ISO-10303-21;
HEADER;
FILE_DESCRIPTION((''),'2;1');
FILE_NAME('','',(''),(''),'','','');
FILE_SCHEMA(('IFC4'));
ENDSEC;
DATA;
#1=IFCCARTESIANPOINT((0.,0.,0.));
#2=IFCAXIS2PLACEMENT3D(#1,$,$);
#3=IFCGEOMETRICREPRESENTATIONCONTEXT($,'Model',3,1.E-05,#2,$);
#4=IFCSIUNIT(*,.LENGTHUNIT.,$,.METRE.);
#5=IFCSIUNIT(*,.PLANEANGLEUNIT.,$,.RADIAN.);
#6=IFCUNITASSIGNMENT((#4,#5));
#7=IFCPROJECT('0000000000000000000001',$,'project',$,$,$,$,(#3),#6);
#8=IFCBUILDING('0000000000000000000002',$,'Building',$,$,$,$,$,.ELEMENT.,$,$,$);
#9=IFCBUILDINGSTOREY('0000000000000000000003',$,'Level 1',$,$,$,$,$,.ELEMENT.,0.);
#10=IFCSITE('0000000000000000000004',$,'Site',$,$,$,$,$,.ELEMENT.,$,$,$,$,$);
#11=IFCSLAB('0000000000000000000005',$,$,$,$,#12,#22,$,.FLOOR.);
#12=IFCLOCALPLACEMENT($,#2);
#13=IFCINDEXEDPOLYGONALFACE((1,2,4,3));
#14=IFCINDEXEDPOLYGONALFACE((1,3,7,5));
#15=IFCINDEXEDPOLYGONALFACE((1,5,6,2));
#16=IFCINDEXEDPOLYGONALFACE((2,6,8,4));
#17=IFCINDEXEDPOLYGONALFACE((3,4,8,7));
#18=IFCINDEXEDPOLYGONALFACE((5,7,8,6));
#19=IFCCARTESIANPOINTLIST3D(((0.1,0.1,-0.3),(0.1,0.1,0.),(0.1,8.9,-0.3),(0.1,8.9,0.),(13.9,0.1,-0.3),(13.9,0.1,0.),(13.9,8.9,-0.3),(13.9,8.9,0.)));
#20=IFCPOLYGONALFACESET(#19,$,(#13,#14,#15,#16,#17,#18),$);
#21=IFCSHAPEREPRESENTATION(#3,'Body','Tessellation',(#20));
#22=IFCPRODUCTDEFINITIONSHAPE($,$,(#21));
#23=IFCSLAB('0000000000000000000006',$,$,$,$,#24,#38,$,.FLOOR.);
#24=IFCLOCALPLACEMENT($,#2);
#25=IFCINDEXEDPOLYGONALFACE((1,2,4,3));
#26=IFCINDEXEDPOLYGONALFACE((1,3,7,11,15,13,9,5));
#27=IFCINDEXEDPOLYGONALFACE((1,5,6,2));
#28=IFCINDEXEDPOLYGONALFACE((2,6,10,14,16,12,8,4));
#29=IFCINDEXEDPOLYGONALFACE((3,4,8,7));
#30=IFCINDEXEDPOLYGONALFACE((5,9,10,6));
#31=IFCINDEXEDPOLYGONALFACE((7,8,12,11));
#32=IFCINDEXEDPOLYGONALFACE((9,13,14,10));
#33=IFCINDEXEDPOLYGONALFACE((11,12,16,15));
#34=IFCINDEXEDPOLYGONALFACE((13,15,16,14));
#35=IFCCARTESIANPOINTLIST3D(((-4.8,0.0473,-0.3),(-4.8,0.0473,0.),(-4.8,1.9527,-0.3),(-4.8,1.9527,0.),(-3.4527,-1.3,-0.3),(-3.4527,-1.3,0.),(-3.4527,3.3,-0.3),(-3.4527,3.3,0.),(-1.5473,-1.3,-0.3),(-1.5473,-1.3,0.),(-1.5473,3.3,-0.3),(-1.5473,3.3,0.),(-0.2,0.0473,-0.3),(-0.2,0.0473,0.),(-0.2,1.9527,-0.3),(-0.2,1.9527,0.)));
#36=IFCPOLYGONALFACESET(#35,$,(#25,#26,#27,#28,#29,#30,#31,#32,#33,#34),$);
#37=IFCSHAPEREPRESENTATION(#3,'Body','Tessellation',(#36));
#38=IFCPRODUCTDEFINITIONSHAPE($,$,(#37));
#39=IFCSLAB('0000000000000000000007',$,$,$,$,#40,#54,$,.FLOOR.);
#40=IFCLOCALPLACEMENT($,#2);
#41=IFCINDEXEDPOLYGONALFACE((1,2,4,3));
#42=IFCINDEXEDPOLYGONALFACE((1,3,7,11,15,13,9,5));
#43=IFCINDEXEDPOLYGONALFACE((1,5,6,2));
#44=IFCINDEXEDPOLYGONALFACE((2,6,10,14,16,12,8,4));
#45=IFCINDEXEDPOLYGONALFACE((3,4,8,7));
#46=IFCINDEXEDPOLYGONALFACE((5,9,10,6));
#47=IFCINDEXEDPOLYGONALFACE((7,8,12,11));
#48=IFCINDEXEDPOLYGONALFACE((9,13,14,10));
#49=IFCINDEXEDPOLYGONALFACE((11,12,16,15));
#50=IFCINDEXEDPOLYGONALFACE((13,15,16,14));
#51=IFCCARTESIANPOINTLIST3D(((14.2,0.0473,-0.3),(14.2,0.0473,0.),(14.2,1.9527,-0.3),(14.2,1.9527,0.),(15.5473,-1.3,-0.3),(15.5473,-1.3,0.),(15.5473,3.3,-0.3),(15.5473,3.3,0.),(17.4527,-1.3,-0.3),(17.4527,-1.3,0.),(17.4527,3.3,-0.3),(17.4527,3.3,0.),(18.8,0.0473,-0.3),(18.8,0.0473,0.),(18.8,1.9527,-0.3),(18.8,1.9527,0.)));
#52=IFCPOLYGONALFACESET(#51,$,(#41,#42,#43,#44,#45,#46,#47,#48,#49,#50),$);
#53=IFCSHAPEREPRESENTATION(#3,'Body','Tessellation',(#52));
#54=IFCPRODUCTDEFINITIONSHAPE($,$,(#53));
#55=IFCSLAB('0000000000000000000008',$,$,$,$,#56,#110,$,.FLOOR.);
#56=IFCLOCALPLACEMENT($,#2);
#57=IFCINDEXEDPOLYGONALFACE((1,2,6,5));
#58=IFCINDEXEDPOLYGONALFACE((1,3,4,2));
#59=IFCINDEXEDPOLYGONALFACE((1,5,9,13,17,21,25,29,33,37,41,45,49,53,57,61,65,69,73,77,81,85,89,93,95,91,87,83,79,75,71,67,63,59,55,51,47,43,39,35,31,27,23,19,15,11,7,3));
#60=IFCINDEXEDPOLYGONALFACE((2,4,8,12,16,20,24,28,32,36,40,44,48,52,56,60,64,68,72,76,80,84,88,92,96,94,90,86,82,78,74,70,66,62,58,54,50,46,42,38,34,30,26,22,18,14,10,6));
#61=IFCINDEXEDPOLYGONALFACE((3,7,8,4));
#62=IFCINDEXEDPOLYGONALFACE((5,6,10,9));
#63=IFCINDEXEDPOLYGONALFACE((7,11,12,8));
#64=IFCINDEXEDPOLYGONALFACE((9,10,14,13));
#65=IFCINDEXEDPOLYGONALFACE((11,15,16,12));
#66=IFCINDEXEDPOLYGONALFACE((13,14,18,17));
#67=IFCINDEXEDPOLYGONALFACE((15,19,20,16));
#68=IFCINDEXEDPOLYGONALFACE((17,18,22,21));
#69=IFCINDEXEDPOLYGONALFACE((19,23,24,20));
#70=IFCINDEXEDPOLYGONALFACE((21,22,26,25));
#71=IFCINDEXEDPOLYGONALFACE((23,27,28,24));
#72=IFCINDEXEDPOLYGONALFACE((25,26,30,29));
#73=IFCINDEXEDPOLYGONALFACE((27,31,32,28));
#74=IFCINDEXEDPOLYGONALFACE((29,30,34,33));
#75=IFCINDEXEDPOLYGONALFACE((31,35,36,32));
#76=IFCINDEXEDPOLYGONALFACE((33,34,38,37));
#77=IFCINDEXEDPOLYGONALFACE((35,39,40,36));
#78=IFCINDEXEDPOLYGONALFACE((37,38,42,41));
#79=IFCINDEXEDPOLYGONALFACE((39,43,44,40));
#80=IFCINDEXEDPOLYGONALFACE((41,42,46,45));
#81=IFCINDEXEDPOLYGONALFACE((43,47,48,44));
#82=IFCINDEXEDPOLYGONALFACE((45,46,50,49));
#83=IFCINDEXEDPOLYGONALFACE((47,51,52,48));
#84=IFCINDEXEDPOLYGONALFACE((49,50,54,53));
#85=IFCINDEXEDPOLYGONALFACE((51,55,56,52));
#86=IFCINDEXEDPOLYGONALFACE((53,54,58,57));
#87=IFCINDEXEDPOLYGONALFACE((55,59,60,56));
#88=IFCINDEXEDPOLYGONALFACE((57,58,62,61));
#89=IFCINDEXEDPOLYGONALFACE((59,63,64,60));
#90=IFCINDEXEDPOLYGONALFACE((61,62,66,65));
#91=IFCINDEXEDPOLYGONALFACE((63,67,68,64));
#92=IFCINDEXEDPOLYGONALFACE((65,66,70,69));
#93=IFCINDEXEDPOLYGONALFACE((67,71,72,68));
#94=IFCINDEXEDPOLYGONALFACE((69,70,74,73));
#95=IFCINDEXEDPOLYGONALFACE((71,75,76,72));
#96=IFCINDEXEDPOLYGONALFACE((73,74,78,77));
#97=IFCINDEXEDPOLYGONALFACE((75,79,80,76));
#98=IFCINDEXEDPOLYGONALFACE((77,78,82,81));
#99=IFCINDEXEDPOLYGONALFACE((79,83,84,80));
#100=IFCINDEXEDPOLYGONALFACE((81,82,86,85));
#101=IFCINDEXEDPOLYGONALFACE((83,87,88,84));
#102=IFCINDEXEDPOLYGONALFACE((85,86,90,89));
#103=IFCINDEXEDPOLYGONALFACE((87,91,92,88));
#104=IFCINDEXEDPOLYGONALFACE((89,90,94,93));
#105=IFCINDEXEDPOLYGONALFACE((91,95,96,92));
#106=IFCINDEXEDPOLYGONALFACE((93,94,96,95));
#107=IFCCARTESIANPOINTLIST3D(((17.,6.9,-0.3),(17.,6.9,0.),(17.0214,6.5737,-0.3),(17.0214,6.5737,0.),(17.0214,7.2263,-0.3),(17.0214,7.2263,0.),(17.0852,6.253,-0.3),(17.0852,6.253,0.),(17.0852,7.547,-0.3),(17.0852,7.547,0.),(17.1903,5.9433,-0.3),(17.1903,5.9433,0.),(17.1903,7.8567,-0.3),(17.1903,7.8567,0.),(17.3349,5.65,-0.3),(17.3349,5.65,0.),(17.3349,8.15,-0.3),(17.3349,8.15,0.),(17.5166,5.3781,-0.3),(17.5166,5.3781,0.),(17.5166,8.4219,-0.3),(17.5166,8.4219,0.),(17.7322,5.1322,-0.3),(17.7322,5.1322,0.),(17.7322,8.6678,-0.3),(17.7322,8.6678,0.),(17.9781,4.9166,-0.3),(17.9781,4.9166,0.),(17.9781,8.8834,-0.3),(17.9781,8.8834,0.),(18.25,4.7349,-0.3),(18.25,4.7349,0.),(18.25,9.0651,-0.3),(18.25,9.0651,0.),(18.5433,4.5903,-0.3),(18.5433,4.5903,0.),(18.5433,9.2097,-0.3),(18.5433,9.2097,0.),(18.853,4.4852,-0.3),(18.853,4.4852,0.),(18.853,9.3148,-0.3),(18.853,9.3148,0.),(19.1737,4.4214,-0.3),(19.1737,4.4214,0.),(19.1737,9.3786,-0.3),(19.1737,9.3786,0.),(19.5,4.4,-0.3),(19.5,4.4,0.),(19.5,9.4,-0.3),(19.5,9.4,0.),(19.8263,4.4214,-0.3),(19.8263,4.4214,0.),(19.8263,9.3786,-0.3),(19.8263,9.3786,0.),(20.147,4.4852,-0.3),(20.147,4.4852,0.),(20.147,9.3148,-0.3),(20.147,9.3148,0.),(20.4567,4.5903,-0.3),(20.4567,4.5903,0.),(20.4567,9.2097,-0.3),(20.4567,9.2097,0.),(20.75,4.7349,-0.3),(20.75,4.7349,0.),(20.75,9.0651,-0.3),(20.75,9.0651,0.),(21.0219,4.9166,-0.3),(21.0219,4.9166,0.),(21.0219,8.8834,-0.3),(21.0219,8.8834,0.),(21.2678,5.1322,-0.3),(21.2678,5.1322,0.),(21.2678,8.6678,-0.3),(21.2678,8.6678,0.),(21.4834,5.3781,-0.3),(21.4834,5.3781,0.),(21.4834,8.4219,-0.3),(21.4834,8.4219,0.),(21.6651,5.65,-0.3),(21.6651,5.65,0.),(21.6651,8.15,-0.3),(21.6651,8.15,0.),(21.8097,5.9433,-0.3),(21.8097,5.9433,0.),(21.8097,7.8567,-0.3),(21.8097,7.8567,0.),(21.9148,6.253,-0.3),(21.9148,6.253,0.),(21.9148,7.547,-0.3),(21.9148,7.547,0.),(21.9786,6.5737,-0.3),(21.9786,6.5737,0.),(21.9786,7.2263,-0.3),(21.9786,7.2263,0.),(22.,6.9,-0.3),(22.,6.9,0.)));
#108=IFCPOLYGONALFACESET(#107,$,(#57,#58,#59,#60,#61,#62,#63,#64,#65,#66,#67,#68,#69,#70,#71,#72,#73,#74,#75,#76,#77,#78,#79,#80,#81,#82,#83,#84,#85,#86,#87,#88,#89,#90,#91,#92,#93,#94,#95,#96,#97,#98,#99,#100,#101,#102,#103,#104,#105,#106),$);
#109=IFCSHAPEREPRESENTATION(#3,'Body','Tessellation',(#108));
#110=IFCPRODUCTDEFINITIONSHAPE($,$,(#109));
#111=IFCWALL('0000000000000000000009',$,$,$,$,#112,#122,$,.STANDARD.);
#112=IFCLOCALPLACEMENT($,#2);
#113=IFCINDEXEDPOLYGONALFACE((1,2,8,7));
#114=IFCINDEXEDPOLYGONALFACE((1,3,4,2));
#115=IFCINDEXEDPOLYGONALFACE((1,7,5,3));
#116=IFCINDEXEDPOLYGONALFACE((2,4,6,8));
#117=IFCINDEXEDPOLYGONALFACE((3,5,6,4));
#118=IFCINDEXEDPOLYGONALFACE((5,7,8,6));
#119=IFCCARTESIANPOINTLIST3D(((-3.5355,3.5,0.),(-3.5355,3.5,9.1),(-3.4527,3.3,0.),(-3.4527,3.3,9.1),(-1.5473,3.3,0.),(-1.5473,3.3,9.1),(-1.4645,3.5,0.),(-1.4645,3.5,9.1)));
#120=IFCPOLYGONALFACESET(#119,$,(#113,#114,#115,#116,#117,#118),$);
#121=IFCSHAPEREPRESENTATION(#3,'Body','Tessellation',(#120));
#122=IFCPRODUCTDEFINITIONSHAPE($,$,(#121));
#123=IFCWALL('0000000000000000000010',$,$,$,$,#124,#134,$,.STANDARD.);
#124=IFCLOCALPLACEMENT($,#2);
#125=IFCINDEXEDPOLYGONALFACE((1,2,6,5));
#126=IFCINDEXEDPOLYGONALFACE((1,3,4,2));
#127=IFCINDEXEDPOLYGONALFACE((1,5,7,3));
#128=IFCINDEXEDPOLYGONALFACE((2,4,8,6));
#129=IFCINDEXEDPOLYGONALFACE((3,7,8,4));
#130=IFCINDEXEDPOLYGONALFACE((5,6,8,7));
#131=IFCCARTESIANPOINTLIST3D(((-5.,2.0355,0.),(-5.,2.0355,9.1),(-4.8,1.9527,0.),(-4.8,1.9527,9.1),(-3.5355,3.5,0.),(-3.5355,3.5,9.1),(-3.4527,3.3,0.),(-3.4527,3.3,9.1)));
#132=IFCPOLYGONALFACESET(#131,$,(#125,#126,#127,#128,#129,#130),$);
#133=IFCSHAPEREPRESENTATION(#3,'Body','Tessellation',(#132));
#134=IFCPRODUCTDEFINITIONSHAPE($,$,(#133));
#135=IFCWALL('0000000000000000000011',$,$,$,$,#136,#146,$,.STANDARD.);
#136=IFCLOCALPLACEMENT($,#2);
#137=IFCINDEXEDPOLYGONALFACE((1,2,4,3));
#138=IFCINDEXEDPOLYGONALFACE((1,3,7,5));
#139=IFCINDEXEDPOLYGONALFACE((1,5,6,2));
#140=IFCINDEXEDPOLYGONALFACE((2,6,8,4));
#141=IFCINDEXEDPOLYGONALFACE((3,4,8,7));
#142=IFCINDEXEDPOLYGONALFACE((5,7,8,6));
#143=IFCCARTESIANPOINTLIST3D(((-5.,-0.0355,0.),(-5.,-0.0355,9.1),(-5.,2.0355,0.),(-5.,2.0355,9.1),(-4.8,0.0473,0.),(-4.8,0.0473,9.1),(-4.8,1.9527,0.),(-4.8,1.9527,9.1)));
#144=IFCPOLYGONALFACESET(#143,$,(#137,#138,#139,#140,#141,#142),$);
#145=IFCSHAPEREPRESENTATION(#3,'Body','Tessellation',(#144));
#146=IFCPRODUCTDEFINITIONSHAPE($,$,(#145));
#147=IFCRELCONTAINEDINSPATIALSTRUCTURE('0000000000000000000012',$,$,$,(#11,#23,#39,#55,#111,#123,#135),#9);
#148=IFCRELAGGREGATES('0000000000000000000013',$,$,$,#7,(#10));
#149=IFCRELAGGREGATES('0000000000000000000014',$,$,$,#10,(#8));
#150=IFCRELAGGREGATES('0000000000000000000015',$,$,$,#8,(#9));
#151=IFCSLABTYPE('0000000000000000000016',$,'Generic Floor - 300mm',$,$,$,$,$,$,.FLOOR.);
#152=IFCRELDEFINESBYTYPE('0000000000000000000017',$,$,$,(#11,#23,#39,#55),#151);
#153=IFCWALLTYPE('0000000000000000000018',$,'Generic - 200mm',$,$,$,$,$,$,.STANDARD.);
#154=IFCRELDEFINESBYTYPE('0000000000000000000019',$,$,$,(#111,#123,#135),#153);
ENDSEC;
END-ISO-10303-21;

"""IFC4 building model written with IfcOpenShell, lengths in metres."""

from ifc_helpers import new_model, si_unit, frame, origin, place, context, project, spatial, polyline, outline, extrude, type_object, element, save


model = new_model("IFC4")

# Units and contexts
model_context = context("Model", 3, precision=1e-05, world=origin())
ifc_project = project(units=[si_unit("LENGTHUNIT", "METRE"), si_unit("PLANEANGLEUNIT", "RADIAN")], contexts=[model_context])

# Site, building, storey
site = spatial("IfcSite", under=ifc_project, Name="Site", CompositionType="ELEMENT")
building = spatial("IfcBuilding", under=site, Name="Building", CompositionType="ELEMENT")
storey = spatial("IfcBuildingStorey", under=building, Name="Level 1", CompositionType="ELEMENT", Elevation=0.0)

# Slabs
slab_type = type_object("IfcSlabType", Name="Generic Floor - 300mm", PredefinedType="FLOOR")
slab_1_placement = place(None, origin())
element("IfcSlab", 1, at=slab_1_placement, inside=storey, type_object=slab_type, PredefinedType="FLOOR", context=model_context, shape_type="SweptSolid", body=[
    extrude(outline(polyline([(0.1, 0.1), (13.9, 0.1), (13.9, 8.9), (0.1, 8.9), (0.1, 0.1)])), origin(), (0.0, 0.0, -1.0), 0.3),
])
slab_2_placement = place(None, origin())
element("IfcSlab", 2, at=slab_2_placement, inside=storey, type_object=slab_type, PredefinedType="FLOOR", context=model_context, shape_type="SweptSolid", body=[
    extrude(outline(polyline([(-0.2, 1.9527), (-1.5473, 3.3), (-3.4527, 3.3), (-4.8, 1.9527), (-4.8, 0.0473), (-3.4527, -1.3), (-1.5473, -1.3), (-0.2, 0.0473), (-0.2, 1.9527)])), origin(), (0.0, 0.0, -1.0), 0.3),
])
slab_3_placement = place(None, origin())
element("IfcSlab", 3, at=slab_3_placement, inside=storey, type_object=slab_type, PredefinedType="FLOOR", context=model_context, shape_type="SweptSolid", body=[
    extrude(outline(polyline([(18.8, 1.9527), (17.4527, 3.3), (15.5473, 3.3), (14.2, 1.9527), (14.2, 0.0473), (15.5473, -1.3), (17.4527, -1.3), (18.8, 0.0473), (18.8, 1.9527)])), origin(), (0.0, 0.0, -1.0), 0.3),
])
slab_4_placement = place(None, origin())
element("IfcSlab", 4, at=slab_4_placement, inside=storey, type_object=slab_type, PredefinedType="FLOOR", context=model_context, shape_type="SweptSolid", body=[
    extrude(outline(polyline([(22.0, 6.9), (21.9786, 7.2263), (21.9148, 7.547), (21.8097, 7.8567), (21.6651, 8.15), (21.4834, 8.4219), (21.2678, 8.6678), (21.0219, 8.8834), (20.75, 9.0651), (20.4567, 9.2097), (20.147, 9.3148), (19.8263, 9.3786), (19.5, 9.4), (19.1737, 9.3786), (18.853, 9.3148), (18.5433, 9.2097), (18.25, 9.0651), (17.9781, 8.8834), (17.7322, 8.6678), (17.5166, 8.4219), (17.3349, 8.15), (17.1903, 7.8567), (17.0852, 7.547), (17.0214, 7.2263), (17.0, 6.9), (17.0214, 6.5737), (17.0852, 6.253), (17.1903, 5.9433), (17.3349, 5.65), (17.5166, 5.3781), (17.7322, 5.1322), (17.9781, 4.9166), (18.25, 4.7349), (18.5433, 4.5903), (18.853, 4.4852), (19.1737, 4.4214), (19.5, 4.4), (19.8263, 4.4214), (20.147, 4.4852), (20.4567, 4.5903), (20.75, 4.7349), (21.0219, 4.9166), (21.2678, 5.1322), (21.4834, 5.3781), (21.6651, 5.65), (21.8097, 5.9433), (21.9148, 6.253), (21.9786, 6.5737), (22.0, 6.9)])), origin(), (0.0, 0.0, -1.0), 0.3),
])

# Walls
wall_type_1 = type_object("IfcWallType", Name="Generic - 200mm", PredefinedType="STANDARD")
wall_1_placement = place(None, frame((-3.4941, 3.4, 0.0), z_axis=(0.0, 0.0, 1.0), x_axis=(1.0, 0.0, 0.0)))
element("IfcWall", 5, at=wall_1_placement, inside=storey, type_object=wall_type_1, PredefinedType="STANDARD", context=model_context, shape_type="SweptSolid", body=[
    extrude(outline(polyline([(0.0414, -0.1), (1.9468, -0.1), (2.0296, 0.1), (-0.0414, 0.1), (0.0414, -0.1)])), origin(), (0.0, 0.0, 1.0), 9.1),
])
wall_2_placement = place(None, frame((-4.9, 1.9941, 0.0), z_axis=(0.0, 0.0, 1.0), x_axis=(0.707107, 0.707107, 0.0)))
element("IfcWall", 6, at=wall_2_placement, inside=storey, type_object=wall_type_1, PredefinedType="STANDARD", context=model_context, shape_type="SweptSolid", body=[
    extrude(outline(polyline([(0.0414, -0.1), (1.9468, -0.1), (2.0296, 0.1), (-0.0414, 0.1), (0.0414, -0.1)])), origin(), (0.0, 0.0, 1.0), 9.1),
])
wall_3_placement = place(None, frame((-4.9, 0.0059, 0.0), z_axis=(0.0, 0.0, 1.0), x_axis=(0.0, 1.0, 0.0)))
element("IfcWall", 7, at=wall_3_placement, inside=storey, type_object=wall_type_1, PredefinedType="STANDARD", context=model_context, shape_type="SweptSolid", body=[
    extrude(outline(polyline([(0.0414, -0.1), (1.9468, -0.1), (2.0296, 0.1), (-0.0414, 0.1), (0.0414, -0.1)])), origin(), (0.0, 0.0, 1.0), 9.1),
])

save(model, "model.ifc")
